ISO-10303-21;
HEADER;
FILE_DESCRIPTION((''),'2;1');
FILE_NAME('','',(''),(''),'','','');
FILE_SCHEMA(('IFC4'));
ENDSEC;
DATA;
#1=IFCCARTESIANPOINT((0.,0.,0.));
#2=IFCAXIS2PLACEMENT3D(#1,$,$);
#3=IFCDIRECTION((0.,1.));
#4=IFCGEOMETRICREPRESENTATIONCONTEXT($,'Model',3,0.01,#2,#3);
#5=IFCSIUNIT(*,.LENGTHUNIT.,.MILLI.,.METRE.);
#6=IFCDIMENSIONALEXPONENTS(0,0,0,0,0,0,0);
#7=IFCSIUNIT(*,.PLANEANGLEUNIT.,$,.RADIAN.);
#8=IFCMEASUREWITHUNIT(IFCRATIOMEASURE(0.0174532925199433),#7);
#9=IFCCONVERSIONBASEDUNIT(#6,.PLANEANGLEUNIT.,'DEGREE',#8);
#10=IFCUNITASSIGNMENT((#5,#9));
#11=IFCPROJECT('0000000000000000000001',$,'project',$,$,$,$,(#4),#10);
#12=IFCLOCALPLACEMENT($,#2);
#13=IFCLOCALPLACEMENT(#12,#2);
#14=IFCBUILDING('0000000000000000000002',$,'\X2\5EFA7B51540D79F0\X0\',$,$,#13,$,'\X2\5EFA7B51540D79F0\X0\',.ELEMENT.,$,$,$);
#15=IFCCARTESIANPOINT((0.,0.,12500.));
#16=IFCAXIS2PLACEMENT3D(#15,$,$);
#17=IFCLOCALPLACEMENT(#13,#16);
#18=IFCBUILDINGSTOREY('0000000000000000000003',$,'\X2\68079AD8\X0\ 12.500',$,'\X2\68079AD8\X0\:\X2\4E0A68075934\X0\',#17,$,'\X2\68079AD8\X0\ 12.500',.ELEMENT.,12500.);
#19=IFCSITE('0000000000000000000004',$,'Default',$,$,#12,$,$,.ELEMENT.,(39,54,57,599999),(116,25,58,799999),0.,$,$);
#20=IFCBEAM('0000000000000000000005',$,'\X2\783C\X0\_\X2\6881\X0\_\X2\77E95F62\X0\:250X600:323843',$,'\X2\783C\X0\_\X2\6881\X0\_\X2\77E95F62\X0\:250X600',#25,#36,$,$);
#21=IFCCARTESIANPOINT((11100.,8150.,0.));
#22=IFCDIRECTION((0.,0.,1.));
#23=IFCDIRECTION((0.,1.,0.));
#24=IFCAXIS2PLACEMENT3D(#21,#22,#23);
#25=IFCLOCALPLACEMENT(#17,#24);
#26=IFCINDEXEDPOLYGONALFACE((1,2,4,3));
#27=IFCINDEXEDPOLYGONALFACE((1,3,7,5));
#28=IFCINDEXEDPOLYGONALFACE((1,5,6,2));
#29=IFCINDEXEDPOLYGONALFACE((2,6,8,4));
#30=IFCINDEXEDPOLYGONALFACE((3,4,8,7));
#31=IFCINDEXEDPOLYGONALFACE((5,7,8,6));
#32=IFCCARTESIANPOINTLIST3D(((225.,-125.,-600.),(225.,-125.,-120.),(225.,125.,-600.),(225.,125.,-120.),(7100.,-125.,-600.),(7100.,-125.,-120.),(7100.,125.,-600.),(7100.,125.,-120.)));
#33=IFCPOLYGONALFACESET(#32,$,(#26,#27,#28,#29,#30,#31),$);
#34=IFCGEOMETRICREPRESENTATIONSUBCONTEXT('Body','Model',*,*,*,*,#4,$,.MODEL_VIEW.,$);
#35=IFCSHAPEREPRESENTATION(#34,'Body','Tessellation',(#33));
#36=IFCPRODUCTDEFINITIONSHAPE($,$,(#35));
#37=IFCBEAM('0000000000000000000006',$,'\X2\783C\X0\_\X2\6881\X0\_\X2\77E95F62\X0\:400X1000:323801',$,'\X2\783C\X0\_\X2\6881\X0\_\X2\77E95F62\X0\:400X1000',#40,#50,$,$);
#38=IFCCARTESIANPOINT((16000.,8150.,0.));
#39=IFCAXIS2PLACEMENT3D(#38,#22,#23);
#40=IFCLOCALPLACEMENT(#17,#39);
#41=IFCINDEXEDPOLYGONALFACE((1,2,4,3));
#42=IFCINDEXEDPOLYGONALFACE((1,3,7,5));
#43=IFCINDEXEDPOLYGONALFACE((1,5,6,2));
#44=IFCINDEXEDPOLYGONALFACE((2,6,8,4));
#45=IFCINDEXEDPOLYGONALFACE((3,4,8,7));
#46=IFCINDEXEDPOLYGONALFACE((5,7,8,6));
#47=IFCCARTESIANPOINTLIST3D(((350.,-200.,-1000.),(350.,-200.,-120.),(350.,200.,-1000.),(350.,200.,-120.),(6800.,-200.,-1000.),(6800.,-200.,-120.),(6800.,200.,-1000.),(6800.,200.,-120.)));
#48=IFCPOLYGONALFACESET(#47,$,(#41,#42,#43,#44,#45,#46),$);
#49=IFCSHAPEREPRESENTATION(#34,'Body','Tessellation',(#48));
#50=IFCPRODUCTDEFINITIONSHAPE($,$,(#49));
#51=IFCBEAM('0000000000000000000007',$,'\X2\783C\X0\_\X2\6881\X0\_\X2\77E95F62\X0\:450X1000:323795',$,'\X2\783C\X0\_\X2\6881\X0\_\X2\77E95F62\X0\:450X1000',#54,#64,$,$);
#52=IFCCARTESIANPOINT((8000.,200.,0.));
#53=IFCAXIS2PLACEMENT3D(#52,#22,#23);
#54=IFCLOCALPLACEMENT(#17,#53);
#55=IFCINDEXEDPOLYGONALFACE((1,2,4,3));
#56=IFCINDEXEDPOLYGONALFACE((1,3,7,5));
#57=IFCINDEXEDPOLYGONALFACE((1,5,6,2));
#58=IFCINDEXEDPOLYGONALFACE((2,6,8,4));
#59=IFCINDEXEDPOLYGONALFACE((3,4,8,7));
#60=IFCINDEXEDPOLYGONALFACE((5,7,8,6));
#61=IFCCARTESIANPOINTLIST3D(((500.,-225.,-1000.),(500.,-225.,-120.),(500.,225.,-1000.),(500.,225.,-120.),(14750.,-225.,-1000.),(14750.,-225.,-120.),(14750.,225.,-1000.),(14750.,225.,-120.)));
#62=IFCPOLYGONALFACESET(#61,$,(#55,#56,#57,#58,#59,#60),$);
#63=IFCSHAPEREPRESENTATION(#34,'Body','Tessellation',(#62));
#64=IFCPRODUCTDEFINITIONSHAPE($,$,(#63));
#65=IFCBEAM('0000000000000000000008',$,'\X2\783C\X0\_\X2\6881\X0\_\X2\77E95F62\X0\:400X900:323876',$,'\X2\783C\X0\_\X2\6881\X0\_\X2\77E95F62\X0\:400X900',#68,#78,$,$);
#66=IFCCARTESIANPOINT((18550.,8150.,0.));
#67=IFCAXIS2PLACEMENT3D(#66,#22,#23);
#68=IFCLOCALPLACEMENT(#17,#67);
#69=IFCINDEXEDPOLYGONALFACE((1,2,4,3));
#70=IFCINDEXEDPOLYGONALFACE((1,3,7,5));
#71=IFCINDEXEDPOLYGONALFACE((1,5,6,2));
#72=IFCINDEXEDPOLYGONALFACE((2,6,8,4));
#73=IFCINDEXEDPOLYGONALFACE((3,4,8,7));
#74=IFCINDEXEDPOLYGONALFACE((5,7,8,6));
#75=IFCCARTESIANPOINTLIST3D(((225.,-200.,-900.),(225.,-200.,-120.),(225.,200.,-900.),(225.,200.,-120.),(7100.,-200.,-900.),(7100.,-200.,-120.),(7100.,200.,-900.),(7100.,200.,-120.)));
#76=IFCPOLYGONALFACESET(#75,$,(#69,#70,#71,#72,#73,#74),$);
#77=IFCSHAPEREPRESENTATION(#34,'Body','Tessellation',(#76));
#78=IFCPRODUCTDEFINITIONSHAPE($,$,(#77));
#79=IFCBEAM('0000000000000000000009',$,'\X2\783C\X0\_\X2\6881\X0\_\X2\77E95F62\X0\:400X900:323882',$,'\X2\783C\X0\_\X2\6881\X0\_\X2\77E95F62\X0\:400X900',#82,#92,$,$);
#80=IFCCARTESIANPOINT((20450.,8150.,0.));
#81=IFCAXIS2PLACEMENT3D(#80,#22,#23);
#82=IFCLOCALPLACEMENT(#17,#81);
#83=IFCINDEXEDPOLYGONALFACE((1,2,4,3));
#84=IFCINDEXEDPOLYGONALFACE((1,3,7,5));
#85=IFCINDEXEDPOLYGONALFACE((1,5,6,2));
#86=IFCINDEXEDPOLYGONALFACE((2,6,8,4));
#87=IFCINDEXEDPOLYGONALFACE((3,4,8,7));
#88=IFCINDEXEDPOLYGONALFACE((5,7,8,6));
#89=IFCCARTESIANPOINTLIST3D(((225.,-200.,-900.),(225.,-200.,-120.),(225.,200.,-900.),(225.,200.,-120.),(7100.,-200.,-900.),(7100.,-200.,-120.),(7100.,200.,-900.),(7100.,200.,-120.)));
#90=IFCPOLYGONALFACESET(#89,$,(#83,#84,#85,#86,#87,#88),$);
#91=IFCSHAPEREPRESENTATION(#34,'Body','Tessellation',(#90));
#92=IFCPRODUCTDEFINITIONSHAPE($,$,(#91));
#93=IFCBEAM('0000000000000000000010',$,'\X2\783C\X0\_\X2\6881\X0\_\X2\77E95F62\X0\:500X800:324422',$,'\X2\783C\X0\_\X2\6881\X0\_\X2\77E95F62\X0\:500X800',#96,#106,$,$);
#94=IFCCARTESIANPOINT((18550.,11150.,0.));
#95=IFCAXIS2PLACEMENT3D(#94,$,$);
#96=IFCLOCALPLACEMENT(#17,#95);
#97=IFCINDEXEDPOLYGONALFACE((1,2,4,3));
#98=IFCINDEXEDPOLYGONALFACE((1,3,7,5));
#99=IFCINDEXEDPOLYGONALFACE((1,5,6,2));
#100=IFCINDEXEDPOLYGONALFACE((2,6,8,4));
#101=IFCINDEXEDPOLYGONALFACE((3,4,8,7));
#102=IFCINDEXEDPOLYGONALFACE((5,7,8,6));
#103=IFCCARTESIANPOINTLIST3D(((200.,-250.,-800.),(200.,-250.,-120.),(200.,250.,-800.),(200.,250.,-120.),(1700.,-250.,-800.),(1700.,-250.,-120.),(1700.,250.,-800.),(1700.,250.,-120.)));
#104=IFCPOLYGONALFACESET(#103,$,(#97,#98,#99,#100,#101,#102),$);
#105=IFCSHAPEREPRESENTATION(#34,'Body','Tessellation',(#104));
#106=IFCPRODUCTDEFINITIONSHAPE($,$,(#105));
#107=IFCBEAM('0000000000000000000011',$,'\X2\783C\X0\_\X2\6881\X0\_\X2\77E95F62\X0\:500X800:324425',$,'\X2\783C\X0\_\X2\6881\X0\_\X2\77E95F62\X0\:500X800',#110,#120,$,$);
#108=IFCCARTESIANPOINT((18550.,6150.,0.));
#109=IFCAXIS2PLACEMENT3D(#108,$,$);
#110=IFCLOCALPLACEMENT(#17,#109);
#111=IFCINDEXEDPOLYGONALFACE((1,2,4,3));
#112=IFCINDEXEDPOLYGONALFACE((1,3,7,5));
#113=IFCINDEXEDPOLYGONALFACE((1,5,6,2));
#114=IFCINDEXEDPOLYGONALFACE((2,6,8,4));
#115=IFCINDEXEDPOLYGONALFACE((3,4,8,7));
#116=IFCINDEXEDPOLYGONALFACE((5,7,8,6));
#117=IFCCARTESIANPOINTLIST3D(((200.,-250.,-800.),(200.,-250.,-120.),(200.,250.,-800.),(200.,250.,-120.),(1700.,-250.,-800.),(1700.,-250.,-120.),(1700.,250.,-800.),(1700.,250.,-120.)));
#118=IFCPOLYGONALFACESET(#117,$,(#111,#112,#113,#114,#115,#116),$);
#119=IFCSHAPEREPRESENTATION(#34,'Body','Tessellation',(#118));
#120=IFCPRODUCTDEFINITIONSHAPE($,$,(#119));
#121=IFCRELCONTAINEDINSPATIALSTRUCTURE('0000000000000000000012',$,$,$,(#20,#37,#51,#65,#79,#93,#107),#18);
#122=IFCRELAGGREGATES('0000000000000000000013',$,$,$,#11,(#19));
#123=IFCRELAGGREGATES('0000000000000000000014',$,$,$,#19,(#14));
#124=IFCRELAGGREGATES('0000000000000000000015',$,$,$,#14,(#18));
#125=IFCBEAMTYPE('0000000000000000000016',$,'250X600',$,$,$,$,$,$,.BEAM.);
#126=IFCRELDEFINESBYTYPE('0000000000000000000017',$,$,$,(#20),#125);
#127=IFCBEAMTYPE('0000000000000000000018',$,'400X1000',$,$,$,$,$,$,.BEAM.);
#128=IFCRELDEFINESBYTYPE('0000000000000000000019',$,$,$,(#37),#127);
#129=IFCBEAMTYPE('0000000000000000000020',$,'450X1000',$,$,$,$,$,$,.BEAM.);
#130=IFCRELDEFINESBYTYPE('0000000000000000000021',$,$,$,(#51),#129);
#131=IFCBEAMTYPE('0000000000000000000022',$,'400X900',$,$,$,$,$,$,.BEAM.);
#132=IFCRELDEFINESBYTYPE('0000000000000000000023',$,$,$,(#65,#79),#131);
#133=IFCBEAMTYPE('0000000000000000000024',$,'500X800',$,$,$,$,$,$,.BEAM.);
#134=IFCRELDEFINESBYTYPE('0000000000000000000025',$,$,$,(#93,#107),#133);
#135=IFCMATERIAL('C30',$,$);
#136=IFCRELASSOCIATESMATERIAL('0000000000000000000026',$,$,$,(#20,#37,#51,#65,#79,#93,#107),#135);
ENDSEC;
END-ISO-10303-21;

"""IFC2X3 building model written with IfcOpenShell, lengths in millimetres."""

from ifc_helpers import new_model, entity, si_unit, converted_unit, direction, frame, frame_2d, origin, place, context, subcontext, project, spatial, rectangle, extrude, material, type_object, element, save


model = new_model("IFC2X3")

# Units and contexts
model_context = context("Model", 3, precision=0.01, world=origin(), true_north=direction((0.0, 1.0)))
body_context = subcontext(model_context, "Body", "Model", "MODEL_VIEW")
ifc_project = project(units=[si_unit("LENGTHUNIT", "METRE", prefix="MILLI"), converted_unit("PLANEANGLEUNIT", "DEGREE", entity("IfcRatioMeasure", 0.0174532925199433), si_unit("PLANEANGLEUNIT", "RADIAN"), dimensions=[0, 0, 0, 0, 0, 0, 0])], contexts=[model_context])

# Site, building, storey
site_placement = place(None, origin())
site = spatial("IfcSite", under=ifc_project, at=site_placement, Name="Default", CompositionType="ELEMENT", RefLatitude=(39, 54, 57, 599999), RefLongitude=(116, 25, 58, 799999), RefElevation=0.0)
building_placement = place(site_placement, origin())
building = spatial("IfcBuilding", under=site, at=building_placement, Name="建筑名称", LongName="建筑名称", CompositionType="ELEMENT")
storey_placement = place(building_placement, frame((0.0, 0.0, 12500.0)))
storey = spatial("IfcBuildingStorey", under=building, at=storey_placement, Name="标高 12.500", ObjectType="标高:上标头", LongName="标高 12.500", CompositionType="ELEMENT", Elevation=12500.0)

# Shared definitions
ifc_material = material(Name="C30")

# Beams
beam_type_1 = type_object("IfcBeamType", Name="250X600", PredefinedType="BEAM")
beam_1_placement = place(storey_placement, frame((11100.0, 8150.0, 0.0), z_axis=(0.0, 0.0, 1.0), x_axis=(0.0, 1.0, 0.0)))
element("IfcBeam", 1, at=beam_1_placement, inside=storey, type_object=beam_type_1, material=ifc_material, Name="砼_梁_矩形:250X600:323843", ObjectType="砼_梁_矩形:250X600", context=body_context, shape_type="SweptSolid", body=[
    extrude(rectangle(XDim=480.0, YDim=250.0, at=frame_2d((0.0, 0.0), x_axis=(1.0, 0.0))), frame((225.0, 0.0, -360.0), z_axis=(1.0, 0.0, 0.0), x_axis=(0.0, 0.0, -1.0)), (0.0, 0.0, 1.0), 6875.0),
])
beam_type_2 = type_object("IfcBeamType", Name="400X1000", PredefinedType="BEAM")
beam_2_placement = place(storey_placement, frame((16000.0, 8150.0, 0.0), z_axis=(0.0, 0.0, 1.0), x_axis=(0.0, 1.0, 0.0)))
element("IfcBeam", 2, at=beam_2_placement, inside=storey, type_object=beam_type_2, material=ifc_material, Name="砼_梁_矩形:400X1000:323801", ObjectType="砼_梁_矩形:400X1000", context=body_context, shape_type="SweptSolid", body=[
    extrude(rectangle(XDim=880.0, YDim=400.0, at=frame_2d((0.0, 0.0), x_axis=(1.0, 0.0))), frame((350.0, 0.0, -560.0), z_axis=(1.0, 0.0, 0.0), x_axis=(0.0, 0.0, -1.0)), (0.0, 0.0, 1.0), 6450.0),
])
beam_type_3 = type_object("IfcBeamType", Name="450X1000", PredefinedType="BEAM")
beam_3_placement = place(storey_placement, frame((8000.0, 200.0, 0.0), z_axis=(0.0, 0.0, 1.0), x_axis=(0.0, 1.0, 0.0)))
element("IfcBeam", 3, at=beam_3_placement, inside=storey, type_object=beam_type_3, material=ifc_material, Name="砼_梁_矩形:450X1000:323795", ObjectType="砼_梁_矩形:450X1000", context=body_context, shape_type="SweptSolid", body=[
    extrude(rectangle(XDim=880.0, YDim=450.0, at=frame_2d((0.0, 0.0), x_axis=(1.0, 0.0))), frame((500.0, 0.0, -560.0), z_axis=(1.0, 0.0, 0.0), x_axis=(0.0, 0.0, -1.0)), (0.0, 0.0, 1.0), 14250.0),
])
beam_type_4 = type_object("IfcBeamType", Name="400X900", PredefinedType="BEAM")
beam_4_placement = place(storey_placement, frame((18550.0, 8150.0, 0.0), z_axis=(0.0, 0.0, 1.0), x_axis=(0.0, 1.0, 0.0)))
element("IfcBeam", 4, at=beam_4_placement, inside=storey, type_object=beam_type_4, material=ifc_material, Name="砼_梁_矩形:400X900:323876", ObjectType="砼_梁_矩形:400X900", context=body_context, shape_type="SweptSolid", body=[
    extrude(rectangle(XDim=780.0, YDim=400.0, at=frame_2d((0.0, 0.0), x_axis=(1.0, 0.0))), frame((225.0, 0.0, -510.0), z_axis=(1.0, 0.0, 0.0), x_axis=(0.0, 0.0, -1.0)), (0.0, 0.0, 1.0), 6875.0),
])
beam_5_placement = place(storey_placement, frame((20450.0, 8150.0, 0.0), z_axis=(0.0, 0.0, 1.0), x_axis=(0.0, 1.0, 0.0)))
element("IfcBeam", 5, at=beam_5_placement, inside=storey, type_object=beam_type_4, material=ifc_material, Name="砼_梁_矩形:400X900:323882", ObjectType="砼_梁_矩形:400X900", context=body_context, shape_type="SweptSolid", body=[
    extrude(rectangle(XDim=780.0, YDim=400.0, at=frame_2d((0.0, 0.0), x_axis=(1.0, 0.0))), frame((225.0, 0.0, -510.0), z_axis=(1.0, 0.0, 0.0), x_axis=(0.0, 0.0, -1.0)), (0.0, 0.0, 1.0), 6875.0),
])
beam_type_5 = type_object("IfcBeamType", Name="500X800", PredefinedType="BEAM")
for number, where, name in (
    (6, (18550.0, 11150.0, 0.0), "砼_梁_矩形:500X800:324422"),
    (7, (18550.0, 6150.0, 0.0), "砼_梁_矩形:500X800:324425"),
):
    element("IfcBeam", number, at=place(storey_placement, frame(where)), inside=storey, type_object=beam_type_5, material=ifc_material, Name=name, ObjectType="砼_梁_矩形:500X800", context=body_context, shape_type="SweptSolid", body=[
        extrude(rectangle(XDim=680.0, YDim=500.0, at=frame_2d((0.0, 0.0), x_axis=(1.0, 0.0))), frame((200.0, 0.0, -460.0), z_axis=(1.0, 0.0, 0.0), x_axis=(0.0, 0.0, -1.0)), (0.0, 0.0, 1.0), 1500.0),
    ])

save(model, "model.ifc")
